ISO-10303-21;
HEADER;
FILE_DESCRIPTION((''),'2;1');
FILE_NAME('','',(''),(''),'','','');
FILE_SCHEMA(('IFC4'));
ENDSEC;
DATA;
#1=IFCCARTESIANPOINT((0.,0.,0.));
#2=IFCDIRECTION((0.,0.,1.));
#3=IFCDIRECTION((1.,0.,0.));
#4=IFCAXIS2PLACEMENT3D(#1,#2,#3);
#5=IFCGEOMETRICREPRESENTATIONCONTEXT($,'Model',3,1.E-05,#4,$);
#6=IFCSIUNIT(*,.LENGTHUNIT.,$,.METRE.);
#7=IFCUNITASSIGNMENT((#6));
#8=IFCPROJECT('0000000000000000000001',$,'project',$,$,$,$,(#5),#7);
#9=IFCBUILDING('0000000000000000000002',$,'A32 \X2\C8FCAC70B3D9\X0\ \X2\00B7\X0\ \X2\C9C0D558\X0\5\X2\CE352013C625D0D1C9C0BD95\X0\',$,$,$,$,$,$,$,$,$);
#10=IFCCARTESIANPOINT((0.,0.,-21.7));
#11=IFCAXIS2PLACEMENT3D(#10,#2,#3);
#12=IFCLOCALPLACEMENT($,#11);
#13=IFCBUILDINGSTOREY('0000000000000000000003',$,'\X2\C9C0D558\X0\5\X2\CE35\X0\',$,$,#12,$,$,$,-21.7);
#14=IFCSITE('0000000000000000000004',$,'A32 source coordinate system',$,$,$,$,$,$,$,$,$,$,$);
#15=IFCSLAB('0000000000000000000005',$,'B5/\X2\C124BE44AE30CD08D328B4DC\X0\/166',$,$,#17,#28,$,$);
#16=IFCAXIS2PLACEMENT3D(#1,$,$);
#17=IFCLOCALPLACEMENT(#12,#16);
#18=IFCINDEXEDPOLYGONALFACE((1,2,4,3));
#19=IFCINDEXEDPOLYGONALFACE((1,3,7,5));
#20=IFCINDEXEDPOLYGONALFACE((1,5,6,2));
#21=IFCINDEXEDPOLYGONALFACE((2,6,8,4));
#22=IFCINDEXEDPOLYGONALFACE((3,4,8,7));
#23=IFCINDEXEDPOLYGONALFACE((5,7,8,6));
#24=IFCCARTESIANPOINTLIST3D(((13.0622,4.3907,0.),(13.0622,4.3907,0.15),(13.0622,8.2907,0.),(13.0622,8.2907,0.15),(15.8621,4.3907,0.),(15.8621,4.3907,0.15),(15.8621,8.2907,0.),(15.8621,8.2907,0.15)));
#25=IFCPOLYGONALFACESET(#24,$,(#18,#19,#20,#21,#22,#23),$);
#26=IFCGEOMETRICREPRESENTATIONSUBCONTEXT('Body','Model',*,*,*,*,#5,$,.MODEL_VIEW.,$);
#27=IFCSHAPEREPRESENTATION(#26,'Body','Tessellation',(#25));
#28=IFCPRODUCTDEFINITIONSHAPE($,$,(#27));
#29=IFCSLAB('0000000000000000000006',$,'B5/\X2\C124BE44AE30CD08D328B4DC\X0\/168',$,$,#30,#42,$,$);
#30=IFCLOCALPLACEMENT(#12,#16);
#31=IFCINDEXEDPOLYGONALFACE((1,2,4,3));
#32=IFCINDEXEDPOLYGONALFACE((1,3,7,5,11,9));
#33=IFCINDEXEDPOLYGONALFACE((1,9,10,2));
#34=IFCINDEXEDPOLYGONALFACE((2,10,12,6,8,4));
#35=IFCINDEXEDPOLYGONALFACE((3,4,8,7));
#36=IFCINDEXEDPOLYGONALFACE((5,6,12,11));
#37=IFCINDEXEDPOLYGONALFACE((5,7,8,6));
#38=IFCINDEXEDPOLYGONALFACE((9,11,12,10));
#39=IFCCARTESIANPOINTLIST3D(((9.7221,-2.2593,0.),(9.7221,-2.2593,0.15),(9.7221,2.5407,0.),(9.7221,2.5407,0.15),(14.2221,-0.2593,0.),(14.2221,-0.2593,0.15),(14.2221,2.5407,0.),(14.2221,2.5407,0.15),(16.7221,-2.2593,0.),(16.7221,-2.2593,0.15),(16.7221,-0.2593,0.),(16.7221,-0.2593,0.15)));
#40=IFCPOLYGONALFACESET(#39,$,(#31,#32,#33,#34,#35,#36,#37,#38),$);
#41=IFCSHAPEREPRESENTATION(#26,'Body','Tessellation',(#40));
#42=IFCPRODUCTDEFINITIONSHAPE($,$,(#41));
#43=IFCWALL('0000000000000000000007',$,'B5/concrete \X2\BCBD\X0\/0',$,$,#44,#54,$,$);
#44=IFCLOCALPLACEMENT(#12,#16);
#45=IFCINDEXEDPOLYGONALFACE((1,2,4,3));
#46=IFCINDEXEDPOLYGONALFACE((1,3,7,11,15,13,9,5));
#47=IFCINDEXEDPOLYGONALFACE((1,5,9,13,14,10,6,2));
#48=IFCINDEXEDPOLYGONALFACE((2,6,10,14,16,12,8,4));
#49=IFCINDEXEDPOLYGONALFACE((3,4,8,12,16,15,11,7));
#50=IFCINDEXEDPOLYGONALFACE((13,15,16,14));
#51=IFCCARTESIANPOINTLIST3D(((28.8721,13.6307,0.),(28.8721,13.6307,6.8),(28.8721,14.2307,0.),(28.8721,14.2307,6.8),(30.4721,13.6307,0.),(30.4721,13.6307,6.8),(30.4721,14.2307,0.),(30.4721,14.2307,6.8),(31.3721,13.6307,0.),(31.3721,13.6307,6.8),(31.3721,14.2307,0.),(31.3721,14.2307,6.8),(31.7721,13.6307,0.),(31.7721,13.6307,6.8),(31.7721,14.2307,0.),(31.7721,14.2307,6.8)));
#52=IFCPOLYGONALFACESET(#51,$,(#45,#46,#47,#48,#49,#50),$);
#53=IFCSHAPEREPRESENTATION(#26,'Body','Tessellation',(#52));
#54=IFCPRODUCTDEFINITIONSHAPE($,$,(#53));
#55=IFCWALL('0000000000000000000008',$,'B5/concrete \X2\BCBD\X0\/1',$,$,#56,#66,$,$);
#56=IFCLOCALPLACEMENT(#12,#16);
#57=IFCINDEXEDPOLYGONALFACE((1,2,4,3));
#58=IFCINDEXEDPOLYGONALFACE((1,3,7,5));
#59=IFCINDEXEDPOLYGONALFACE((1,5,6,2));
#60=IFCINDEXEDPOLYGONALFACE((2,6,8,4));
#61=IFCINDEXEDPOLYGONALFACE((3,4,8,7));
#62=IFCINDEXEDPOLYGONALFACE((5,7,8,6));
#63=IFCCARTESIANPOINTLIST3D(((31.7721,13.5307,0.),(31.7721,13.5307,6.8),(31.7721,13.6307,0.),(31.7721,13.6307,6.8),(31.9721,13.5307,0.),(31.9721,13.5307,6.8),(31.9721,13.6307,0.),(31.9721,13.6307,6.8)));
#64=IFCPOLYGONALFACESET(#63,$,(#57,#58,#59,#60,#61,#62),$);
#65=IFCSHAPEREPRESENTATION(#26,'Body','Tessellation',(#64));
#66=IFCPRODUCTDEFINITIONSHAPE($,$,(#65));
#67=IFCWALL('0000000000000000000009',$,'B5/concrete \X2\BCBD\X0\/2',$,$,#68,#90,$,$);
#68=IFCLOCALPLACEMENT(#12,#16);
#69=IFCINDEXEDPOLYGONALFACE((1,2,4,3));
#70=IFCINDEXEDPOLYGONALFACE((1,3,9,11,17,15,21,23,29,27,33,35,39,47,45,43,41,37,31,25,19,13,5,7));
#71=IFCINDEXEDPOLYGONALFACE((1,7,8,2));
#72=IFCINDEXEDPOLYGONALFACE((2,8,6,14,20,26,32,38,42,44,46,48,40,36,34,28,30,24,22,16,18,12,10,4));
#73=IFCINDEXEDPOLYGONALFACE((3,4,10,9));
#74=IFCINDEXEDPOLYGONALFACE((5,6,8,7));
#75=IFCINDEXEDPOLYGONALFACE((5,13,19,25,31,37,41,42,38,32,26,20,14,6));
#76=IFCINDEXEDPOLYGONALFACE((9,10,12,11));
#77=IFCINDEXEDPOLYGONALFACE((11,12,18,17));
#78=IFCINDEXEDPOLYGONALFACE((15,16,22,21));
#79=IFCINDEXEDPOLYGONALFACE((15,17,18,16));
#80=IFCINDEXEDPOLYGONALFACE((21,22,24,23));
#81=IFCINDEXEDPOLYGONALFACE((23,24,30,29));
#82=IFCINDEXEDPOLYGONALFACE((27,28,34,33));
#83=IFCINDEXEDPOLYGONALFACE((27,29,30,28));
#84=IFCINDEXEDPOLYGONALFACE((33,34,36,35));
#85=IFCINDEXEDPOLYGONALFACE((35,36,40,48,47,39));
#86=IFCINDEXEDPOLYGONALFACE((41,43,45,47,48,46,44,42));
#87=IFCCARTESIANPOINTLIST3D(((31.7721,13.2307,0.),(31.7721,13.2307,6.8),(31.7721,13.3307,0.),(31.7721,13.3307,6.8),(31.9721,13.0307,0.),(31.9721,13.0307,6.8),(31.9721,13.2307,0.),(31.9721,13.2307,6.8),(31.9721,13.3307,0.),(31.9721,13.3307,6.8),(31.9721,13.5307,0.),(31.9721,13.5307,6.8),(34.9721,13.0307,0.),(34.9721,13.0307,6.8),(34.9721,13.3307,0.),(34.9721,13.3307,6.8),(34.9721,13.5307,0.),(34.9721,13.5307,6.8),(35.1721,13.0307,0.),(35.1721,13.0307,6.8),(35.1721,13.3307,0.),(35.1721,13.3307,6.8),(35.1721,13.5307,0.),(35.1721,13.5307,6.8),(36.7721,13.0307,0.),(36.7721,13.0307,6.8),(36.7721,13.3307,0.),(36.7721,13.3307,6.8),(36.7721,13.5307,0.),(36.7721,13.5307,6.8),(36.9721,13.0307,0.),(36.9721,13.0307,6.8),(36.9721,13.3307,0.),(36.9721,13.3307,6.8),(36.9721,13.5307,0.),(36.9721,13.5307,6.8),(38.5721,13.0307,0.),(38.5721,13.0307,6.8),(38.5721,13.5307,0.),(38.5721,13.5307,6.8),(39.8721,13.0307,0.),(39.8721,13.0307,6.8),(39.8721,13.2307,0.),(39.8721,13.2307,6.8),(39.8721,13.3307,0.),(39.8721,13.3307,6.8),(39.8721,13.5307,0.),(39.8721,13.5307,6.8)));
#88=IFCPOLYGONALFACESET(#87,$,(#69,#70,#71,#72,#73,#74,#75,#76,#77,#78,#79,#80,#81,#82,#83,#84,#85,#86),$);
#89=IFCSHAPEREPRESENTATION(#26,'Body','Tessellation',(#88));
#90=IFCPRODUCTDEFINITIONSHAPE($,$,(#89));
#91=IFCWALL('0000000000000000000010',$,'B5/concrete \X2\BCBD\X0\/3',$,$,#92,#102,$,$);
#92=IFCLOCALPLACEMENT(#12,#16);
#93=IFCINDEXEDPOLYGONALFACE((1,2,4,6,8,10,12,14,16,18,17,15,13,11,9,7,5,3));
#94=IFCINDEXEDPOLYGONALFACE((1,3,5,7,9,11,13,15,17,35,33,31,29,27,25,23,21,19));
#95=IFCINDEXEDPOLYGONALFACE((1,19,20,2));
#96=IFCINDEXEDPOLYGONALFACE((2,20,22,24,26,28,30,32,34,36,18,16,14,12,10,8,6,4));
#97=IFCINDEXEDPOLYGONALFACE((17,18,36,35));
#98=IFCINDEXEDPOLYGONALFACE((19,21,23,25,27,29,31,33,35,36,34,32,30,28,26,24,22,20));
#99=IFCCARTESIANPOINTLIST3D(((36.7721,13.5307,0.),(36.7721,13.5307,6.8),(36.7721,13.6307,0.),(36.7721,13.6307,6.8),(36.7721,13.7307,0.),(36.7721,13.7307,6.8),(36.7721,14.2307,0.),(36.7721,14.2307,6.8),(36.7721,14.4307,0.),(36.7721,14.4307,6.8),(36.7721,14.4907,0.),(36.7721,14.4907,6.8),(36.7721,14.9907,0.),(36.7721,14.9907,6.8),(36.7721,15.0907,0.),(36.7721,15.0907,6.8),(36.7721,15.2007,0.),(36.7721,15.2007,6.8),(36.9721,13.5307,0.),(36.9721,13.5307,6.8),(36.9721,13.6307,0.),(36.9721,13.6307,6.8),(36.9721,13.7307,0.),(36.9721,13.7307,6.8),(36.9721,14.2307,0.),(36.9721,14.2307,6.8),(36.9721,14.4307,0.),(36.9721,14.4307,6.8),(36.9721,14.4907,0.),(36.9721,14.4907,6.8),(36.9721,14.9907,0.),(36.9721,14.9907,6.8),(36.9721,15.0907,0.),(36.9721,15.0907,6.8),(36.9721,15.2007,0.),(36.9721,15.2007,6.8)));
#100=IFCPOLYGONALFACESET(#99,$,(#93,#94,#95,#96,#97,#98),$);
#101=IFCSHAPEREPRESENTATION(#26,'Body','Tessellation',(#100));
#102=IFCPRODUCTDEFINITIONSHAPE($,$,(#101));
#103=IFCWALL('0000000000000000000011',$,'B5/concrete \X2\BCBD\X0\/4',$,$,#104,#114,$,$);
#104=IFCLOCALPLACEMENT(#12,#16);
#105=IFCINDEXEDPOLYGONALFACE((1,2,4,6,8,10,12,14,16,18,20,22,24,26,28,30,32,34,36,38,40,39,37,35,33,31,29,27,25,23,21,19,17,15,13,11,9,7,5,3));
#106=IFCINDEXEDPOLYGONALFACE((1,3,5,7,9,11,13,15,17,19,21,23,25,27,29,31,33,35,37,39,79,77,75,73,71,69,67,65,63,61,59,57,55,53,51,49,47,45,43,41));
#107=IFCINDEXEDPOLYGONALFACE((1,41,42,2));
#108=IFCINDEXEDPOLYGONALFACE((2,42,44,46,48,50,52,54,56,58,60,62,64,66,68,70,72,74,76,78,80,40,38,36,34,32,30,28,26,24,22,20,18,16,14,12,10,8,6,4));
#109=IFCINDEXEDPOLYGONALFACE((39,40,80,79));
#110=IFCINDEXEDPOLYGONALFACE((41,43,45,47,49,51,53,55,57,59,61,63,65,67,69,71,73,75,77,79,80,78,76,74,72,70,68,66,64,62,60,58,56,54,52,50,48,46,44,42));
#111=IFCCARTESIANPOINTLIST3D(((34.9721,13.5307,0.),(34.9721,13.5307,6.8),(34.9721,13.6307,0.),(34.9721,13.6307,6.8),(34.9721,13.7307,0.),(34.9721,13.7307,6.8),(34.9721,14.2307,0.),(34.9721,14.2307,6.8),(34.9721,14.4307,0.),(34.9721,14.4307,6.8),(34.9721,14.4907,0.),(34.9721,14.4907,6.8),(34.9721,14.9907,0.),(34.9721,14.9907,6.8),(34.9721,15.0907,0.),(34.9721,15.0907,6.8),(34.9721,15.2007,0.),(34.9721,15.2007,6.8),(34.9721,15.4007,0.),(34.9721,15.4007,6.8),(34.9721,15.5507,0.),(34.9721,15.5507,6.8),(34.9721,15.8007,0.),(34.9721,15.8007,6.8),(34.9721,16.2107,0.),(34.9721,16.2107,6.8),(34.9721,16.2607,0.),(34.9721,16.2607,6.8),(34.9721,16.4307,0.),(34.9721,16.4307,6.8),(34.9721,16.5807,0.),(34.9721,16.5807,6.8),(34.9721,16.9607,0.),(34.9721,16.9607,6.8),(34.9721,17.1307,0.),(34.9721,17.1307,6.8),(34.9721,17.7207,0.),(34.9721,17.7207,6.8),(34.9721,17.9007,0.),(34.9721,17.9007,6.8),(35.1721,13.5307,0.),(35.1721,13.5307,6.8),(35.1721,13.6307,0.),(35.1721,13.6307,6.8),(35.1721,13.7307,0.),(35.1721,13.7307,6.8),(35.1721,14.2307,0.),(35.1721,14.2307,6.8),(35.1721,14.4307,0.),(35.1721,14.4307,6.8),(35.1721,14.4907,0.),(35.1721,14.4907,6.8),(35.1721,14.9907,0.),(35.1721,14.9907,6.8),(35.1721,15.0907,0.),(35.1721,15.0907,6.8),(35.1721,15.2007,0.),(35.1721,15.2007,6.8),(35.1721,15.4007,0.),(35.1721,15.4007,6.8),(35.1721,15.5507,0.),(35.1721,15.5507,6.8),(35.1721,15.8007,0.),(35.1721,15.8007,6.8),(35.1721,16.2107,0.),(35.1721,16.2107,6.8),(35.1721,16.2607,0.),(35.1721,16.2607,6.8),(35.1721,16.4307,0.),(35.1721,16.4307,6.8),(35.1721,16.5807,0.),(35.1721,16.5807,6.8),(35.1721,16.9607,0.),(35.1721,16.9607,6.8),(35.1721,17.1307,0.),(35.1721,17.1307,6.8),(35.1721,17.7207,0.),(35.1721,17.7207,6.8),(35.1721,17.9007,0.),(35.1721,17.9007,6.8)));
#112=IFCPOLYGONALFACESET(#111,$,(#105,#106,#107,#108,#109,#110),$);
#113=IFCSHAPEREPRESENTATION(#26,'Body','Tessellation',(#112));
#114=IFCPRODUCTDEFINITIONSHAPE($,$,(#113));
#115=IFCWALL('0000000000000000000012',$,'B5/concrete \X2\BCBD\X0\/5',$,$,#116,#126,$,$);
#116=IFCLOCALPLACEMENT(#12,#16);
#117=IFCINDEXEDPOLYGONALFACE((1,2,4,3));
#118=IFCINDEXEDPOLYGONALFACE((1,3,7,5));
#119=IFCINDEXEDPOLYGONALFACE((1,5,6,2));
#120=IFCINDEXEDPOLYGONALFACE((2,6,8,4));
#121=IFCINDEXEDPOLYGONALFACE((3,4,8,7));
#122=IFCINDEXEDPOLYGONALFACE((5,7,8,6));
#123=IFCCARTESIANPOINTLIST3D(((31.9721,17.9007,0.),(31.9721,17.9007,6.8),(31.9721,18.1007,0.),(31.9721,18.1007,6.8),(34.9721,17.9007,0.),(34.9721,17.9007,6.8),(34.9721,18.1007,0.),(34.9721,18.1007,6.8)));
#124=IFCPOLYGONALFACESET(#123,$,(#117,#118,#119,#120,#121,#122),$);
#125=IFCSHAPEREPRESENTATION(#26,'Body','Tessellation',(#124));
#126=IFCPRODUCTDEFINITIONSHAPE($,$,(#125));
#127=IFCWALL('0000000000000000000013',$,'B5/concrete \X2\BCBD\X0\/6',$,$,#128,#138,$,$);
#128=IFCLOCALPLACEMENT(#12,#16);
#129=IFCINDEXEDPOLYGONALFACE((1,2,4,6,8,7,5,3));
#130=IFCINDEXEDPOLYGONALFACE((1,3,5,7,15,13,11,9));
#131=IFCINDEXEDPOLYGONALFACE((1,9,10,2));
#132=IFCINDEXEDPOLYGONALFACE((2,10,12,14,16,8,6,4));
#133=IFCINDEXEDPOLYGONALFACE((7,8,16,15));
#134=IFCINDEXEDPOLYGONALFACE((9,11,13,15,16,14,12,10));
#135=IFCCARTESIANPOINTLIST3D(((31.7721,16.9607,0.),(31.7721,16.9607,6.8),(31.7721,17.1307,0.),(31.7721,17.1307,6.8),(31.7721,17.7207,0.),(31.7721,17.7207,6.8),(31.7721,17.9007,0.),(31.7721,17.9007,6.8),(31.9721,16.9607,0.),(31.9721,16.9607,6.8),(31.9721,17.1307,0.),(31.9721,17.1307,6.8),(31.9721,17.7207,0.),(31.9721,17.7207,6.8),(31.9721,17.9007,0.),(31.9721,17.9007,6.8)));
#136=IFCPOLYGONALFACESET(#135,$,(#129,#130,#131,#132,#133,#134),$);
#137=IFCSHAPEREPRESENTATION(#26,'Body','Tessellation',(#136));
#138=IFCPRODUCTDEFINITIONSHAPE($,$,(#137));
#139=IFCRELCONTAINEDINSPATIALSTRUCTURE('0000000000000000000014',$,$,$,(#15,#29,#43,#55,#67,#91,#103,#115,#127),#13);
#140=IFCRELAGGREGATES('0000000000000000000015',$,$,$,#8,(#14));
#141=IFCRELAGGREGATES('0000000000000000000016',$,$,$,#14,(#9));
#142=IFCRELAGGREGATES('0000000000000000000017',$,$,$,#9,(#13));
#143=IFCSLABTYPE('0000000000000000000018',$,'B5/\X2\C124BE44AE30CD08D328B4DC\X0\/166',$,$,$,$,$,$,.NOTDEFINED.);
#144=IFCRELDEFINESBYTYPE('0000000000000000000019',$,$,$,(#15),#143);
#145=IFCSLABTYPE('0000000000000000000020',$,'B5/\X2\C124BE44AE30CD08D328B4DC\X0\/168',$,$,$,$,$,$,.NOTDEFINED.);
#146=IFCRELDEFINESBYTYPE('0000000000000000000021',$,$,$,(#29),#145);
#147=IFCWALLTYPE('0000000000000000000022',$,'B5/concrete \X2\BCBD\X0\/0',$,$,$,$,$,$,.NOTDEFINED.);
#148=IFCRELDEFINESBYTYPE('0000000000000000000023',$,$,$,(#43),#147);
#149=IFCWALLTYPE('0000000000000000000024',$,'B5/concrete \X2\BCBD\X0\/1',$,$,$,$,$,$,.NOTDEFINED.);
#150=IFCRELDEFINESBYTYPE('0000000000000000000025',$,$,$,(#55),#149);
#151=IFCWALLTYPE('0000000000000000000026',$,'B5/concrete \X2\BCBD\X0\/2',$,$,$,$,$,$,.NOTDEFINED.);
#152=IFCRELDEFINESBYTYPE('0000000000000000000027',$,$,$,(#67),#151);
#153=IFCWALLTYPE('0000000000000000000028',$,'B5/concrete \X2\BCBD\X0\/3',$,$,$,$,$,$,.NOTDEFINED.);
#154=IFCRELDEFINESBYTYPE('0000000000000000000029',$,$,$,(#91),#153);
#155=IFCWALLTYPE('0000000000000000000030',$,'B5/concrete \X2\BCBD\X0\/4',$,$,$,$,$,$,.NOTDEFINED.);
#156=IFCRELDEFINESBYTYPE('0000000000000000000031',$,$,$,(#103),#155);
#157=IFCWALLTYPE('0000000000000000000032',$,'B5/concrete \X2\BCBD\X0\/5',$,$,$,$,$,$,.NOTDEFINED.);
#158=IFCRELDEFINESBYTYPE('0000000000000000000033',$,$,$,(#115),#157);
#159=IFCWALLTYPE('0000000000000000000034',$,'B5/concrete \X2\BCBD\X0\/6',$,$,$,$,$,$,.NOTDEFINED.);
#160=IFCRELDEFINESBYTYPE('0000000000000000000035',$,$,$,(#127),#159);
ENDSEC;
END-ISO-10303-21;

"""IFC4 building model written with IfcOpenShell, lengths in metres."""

from ifc_helpers import new_model, si_unit, frame, origin, origin_with_axes, place, context, subcontext, project, spatial, polyline, outline, extrude, source, transform, mapped, type_object, type_shapes, element, save


model = new_model("IFC4")

# Units and contexts
model_context = context("Model", 3, precision=1e-05, world=origin_with_axes())
body_context = subcontext(model_context, "Body", "Model", "MODEL_VIEW")
ifc_project = project(units=[si_unit("LENGTHUNIT", "METRE")], contexts=[model_context])

# Site, building, storey
site = spatial("IfcSite", under=ifc_project, Name="A32 source coordinate system")
building = spatial("IfcBuilding", under=site, Name="A32 주거동 · 지하5층–옥탑지붕")
storey_placement = place(None, frame((0.0, 0.0, -21.7), z_axis=(0.0, 0.0, 1.0), x_axis=(1.0, 0.0, 0.0)))
storey = spatial("IfcBuildingStorey", under=building, at=storey_placement, Name="지하5층", Elevation=-21.7)

# Slabs
slab_type_1 = type_object("IfcSlabType", Name="B5/설비기초패드/166", PredefinedType="NOTDEFINED")
shared_shape_1 = source(origin(), body_context, "Body", "SweptSolid", [
    extrude(outline(polyline([(15.8621, 8.2907), (15.8621, 4.3907), (13.0622, 4.3907), (13.0622, 8.2907), (15.8621, 8.2907)])), origin(), (0.0, 0.0, 1.0), 0.15),
])
type_shapes(slab_type_1, [shared_shape_1])
slab_1_placement = place(storey_placement, origin_with_axes())
element("IfcSlab", 1, at=slab_1_placement, inside=storey, type_object=slab_type_1, Name="B5/설비기초패드/166", context=body_context, shape_type="MappedRepresentation", body=[
    mapped(shared_shape_1, transform((0.0, 0.0, 0.0), scale=1.0)),
])
slab_type_2 = type_object("IfcSlabType", Name="B5/설비기초패드/168", PredefinedType="NOTDEFINED")
shared_shape_2 = source(origin(), body_context, "Body", "SweptSolid", [
    extrude(outline(polyline([(14.2221, 2.5407), (14.2221, -0.2593), (16.7221, -0.2593), (16.7221, -2.2593), (9.7221, -2.2593), (9.7221, 2.5407), (14.2221, 2.5407)])), origin(), (0.0, 0.0, 1.0), 0.15),
])
type_shapes(slab_type_2, [shared_shape_2])
slab_2_placement = place(storey_placement, origin_with_axes())
element("IfcSlab", 2, at=slab_2_placement, inside=storey, type_object=slab_type_2, Name="B5/설비기초패드/168", context=body_context, shape_type="MappedRepresentation", body=[
    mapped(shared_shape_2, transform((0.0, 0.0, 0.0), scale=1.0)),
])

# Walls
wall_type_1 = type_object("IfcWallType", Name="B5/concrete 벽/0", PredefinedType="NOTDEFINED")
shared_shape_3 = source(origin(), body_context, "Body", "SweptSolid", [
    extrude(outline(polyline([(31.7721, 13.6307), (31.3721, 13.6307), (30.4721, 13.6307), (28.8721, 13.6307), (28.8721, 14.2307), (30.4721, 14.2307), (31.3721, 14.2307), (31.7721, 14.2307), (31.7721, 13.6307)])), origin(), (0.0, 0.0, 1.0), 6.8),
])
type_shapes(wall_type_1, [shared_shape_3])
wall_1_placement = place(storey_placement, origin_with_axes())
element("IfcWall", 3, at=wall_1_placement, inside=storey, type_object=wall_type_1, Name="B5/concrete 벽/0", context=body_context, shape_type="MappedRepresentation", body=[
    mapped(shared_shape_3, transform((0.0, 0.0, 0.0), scale=1.0)),
])
wall_type_2 = type_object("IfcWallType", Name="B5/concrete 벽/1", PredefinedType="NOTDEFINED")
shared_shape_4 = source(origin(), body_context, "Body", "SweptSolid", [
    extrude(outline(polyline([(31.7721, 13.5307), (31.7721, 13.6307), (31.9721, 13.6307), (31.9721, 13.5307), (31.7721, 13.5307)])), origin(), (0.0, 0.0, 1.0), 6.8),
])
type_shapes(wall_type_2, [shared_shape_4])
wall_2_placement = place(storey_placement, origin_with_axes())
element("IfcWall", 4, at=wall_2_placement, inside=storey, type_object=wall_type_2, Name="B5/concrete 벽/1", context=body_context, shape_type="MappedRepresentation", body=[
    mapped(shared_shape_4, transform((0.0, 0.0, 0.0), scale=1.0)),
])
wall_type_3 = type_object("IfcWallType", Name="B5/concrete 벽/2", PredefinedType="NOTDEFINED")
shared_shape_5 = source(origin(), body_context, "Body", "SweptSolid", [
    extrude(outline(polyline([(35.1721, 13.3307), (35.1721, 13.5307), (36.7721, 13.5307), (36.7721, 13.3307), (36.9721, 13.3307), (36.9721, 13.5307), (38.5721, 13.5307), (39.8721, 13.5307), (39.8721, 13.3307), (39.8721, 13.2307), (39.8721, 13.0307), (38.5721, 13.0307), (36.9721, 13.0307), (36.7721, 13.0307), (35.1721, 13.0307), (34.9721, 13.0307), (31.9721, 13.0307), (31.9721, 13.2307), (31.7721, 13.2307), (31.7721, 13.3307), (31.9721, 13.3307), (31.9721, 13.5307), (34.9721, 13.5307), (34.9721, 13.3307), (35.1721, 13.3307)])), origin(), (0.0, 0.0, 1.0), 6.8),
])
type_shapes(wall_type_3, [shared_shape_5])
wall_3_placement = place(storey_placement, origin_with_axes())
element("IfcWall", 5, at=wall_3_placement, inside=storey, type_object=wall_type_3, Name="B5/concrete 벽/2", context=body_context, shape_type="MappedRepresentation", body=[
    mapped(shared_shape_5, transform((0.0, 0.0, 0.0), scale=1.0)),
])
wall_type_4 = type_object("IfcWallType", Name="B5/concrete 벽/3", PredefinedType="NOTDEFINED")
shared_shape_6 = source(origin(), body_context, "Body", "SweptSolid", [
    extrude(outline(polyline([(36.7721, 13.7307), (36.7721, 14.2307), (36.7721, 14.4307), (36.7721, 14.4907), (36.7721, 14.9907), (36.7721, 15.0907), (36.7721, 15.2007), (36.9721, 15.2007), (36.9721, 15.0907), (36.9721, 14.9907), (36.9721, 14.4907), (36.9721, 14.4307), (36.9721, 14.2307), (36.9721, 13.7307), (36.9721, 13.6307), (36.9721, 13.5307), (36.7721, 13.5307), (36.7721, 13.6307), (36.7721, 13.7307)])), origin(), (0.0, 0.0, 1.0), 6.8),
])
type_shapes(wall_type_4, [shared_shape_6])
wall_4_placement = place(storey_placement, origin_with_axes())
element("IfcWall", 6, at=wall_4_placement, inside=storey, type_object=wall_type_4, Name="B5/concrete 벽/3", context=body_context, shape_type="MappedRepresentation", body=[
    mapped(shared_shape_6, transform((0.0, 0.0, 0.0), scale=1.0)),
])
wall_type_5 = type_object("IfcWallType", Name="B5/concrete 벽/4", PredefinedType="NOTDEFINED")
shared_shape_7 = source(origin(), body_context, "Body", "SweptSolid", [
    extrude(outline(polyline([(34.9721, 13.7307), (34.9721, 14.2307), (34.9721, 14.4307), (34.9721, 14.4907), (34.9721, 14.9907), (34.9721, 15.0907), (34.9721, 15.2007), (34.9721, 15.4007), (34.9721, 15.5507), (34.9721, 15.8007), (34.9721, 16.2107), (34.9721, 16.2607), (34.9721, 16.4307), (34.9721, 16.5807), (34.9721, 16.9607), (34.9721, 17.1307), (34.9721, 17.7207), (34.9721, 17.9007), (35.1721, 17.9007), (35.1721, 17.7207), (35.1721, 17.1307), (35.1721, 16.9607), (35.1721, 16.5807), (35.1721, 16.4307), (35.1721, 16.2607), (35.1721, 16.2107), (35.1721, 15.8007), (35.1721, 15.5507), (35.1721, 15.4007), (35.1721, 15.2007), (35.1721, 15.0907), (35.1721, 14.9907), (35.1721, 14.4907), (35.1721, 14.4307), (35.1721, 14.2307), (35.1721, 13.7307), (35.1721, 13.6307), (35.1721, 13.5307), (34.9721, 13.5307), (34.9721, 13.6307), (34.9721, 13.7307)])), origin(), (0.0, 0.0, 1.0), 6.8),
])
type_shapes(wall_type_5, [shared_shape_7])
wall_5_placement = place(storey_placement, origin_with_axes())
element("IfcWall", 7, at=wall_5_placement, inside=storey, type_object=wall_type_5, Name="B5/concrete 벽/4", context=body_context, shape_type="MappedRepresentation", body=[
    mapped(shared_shape_7, transform((0.0, 0.0, 0.0), scale=1.0)),
])
wall_type_6 = type_object("IfcWallType", Name="B5/concrete 벽/5", PredefinedType="NOTDEFINED")
shared_shape_8 = source(origin(), body_context, "Body", "SweptSolid", [
    extrude(outline(polyline([(34.9721, 18.1007), (34.9721, 17.9007), (31.9721, 17.9007), (31.9721, 18.1007), (34.9721, 18.1007)])), origin(), (0.0, 0.0, 1.0), 6.8),
])
type_shapes(wall_type_6, [shared_shape_8])
wall_6_placement = place(storey_placement, origin_with_axes())
element("IfcWall", 8, at=wall_6_placement, inside=storey, type_object=wall_type_6, Name="B5/concrete 벽/5", context=body_context, shape_type="MappedRepresentation", body=[
    mapped(shared_shape_8, transform((0.0, 0.0, 0.0), scale=1.0)),
])
wall_type_7 = type_object("IfcWallType", Name="B5/concrete 벽/6", PredefinedType="NOTDEFINED")
shared_shape_9 = source(origin(), body_context, "Body", "SweptSolid", [
    extrude(outline(polyline([(31.9721, 16.9607), (31.7721, 16.9607), (31.7721, 17.1307), (31.7721, 17.7207), (31.7721, 17.9007), (31.9721, 17.9007), (31.9721, 17.7207), (31.9721, 17.1307), (31.9721, 16.9607)])), origin(), (0.0, 0.0, 1.0), 6.8),
])
type_shapes(wall_type_7, [shared_shape_9])
wall_7_placement = place(storey_placement, origin_with_axes())
element("IfcWall", 9, at=wall_7_placement, inside=storey, type_object=wall_type_7, Name="B5/concrete 벽/6", context=body_context, shape_type="MappedRepresentation", body=[
    mapped(shared_shape_9, transform((0.0, 0.0, 0.0), scale=1.0)),
])

save(model, "model.ifc")
